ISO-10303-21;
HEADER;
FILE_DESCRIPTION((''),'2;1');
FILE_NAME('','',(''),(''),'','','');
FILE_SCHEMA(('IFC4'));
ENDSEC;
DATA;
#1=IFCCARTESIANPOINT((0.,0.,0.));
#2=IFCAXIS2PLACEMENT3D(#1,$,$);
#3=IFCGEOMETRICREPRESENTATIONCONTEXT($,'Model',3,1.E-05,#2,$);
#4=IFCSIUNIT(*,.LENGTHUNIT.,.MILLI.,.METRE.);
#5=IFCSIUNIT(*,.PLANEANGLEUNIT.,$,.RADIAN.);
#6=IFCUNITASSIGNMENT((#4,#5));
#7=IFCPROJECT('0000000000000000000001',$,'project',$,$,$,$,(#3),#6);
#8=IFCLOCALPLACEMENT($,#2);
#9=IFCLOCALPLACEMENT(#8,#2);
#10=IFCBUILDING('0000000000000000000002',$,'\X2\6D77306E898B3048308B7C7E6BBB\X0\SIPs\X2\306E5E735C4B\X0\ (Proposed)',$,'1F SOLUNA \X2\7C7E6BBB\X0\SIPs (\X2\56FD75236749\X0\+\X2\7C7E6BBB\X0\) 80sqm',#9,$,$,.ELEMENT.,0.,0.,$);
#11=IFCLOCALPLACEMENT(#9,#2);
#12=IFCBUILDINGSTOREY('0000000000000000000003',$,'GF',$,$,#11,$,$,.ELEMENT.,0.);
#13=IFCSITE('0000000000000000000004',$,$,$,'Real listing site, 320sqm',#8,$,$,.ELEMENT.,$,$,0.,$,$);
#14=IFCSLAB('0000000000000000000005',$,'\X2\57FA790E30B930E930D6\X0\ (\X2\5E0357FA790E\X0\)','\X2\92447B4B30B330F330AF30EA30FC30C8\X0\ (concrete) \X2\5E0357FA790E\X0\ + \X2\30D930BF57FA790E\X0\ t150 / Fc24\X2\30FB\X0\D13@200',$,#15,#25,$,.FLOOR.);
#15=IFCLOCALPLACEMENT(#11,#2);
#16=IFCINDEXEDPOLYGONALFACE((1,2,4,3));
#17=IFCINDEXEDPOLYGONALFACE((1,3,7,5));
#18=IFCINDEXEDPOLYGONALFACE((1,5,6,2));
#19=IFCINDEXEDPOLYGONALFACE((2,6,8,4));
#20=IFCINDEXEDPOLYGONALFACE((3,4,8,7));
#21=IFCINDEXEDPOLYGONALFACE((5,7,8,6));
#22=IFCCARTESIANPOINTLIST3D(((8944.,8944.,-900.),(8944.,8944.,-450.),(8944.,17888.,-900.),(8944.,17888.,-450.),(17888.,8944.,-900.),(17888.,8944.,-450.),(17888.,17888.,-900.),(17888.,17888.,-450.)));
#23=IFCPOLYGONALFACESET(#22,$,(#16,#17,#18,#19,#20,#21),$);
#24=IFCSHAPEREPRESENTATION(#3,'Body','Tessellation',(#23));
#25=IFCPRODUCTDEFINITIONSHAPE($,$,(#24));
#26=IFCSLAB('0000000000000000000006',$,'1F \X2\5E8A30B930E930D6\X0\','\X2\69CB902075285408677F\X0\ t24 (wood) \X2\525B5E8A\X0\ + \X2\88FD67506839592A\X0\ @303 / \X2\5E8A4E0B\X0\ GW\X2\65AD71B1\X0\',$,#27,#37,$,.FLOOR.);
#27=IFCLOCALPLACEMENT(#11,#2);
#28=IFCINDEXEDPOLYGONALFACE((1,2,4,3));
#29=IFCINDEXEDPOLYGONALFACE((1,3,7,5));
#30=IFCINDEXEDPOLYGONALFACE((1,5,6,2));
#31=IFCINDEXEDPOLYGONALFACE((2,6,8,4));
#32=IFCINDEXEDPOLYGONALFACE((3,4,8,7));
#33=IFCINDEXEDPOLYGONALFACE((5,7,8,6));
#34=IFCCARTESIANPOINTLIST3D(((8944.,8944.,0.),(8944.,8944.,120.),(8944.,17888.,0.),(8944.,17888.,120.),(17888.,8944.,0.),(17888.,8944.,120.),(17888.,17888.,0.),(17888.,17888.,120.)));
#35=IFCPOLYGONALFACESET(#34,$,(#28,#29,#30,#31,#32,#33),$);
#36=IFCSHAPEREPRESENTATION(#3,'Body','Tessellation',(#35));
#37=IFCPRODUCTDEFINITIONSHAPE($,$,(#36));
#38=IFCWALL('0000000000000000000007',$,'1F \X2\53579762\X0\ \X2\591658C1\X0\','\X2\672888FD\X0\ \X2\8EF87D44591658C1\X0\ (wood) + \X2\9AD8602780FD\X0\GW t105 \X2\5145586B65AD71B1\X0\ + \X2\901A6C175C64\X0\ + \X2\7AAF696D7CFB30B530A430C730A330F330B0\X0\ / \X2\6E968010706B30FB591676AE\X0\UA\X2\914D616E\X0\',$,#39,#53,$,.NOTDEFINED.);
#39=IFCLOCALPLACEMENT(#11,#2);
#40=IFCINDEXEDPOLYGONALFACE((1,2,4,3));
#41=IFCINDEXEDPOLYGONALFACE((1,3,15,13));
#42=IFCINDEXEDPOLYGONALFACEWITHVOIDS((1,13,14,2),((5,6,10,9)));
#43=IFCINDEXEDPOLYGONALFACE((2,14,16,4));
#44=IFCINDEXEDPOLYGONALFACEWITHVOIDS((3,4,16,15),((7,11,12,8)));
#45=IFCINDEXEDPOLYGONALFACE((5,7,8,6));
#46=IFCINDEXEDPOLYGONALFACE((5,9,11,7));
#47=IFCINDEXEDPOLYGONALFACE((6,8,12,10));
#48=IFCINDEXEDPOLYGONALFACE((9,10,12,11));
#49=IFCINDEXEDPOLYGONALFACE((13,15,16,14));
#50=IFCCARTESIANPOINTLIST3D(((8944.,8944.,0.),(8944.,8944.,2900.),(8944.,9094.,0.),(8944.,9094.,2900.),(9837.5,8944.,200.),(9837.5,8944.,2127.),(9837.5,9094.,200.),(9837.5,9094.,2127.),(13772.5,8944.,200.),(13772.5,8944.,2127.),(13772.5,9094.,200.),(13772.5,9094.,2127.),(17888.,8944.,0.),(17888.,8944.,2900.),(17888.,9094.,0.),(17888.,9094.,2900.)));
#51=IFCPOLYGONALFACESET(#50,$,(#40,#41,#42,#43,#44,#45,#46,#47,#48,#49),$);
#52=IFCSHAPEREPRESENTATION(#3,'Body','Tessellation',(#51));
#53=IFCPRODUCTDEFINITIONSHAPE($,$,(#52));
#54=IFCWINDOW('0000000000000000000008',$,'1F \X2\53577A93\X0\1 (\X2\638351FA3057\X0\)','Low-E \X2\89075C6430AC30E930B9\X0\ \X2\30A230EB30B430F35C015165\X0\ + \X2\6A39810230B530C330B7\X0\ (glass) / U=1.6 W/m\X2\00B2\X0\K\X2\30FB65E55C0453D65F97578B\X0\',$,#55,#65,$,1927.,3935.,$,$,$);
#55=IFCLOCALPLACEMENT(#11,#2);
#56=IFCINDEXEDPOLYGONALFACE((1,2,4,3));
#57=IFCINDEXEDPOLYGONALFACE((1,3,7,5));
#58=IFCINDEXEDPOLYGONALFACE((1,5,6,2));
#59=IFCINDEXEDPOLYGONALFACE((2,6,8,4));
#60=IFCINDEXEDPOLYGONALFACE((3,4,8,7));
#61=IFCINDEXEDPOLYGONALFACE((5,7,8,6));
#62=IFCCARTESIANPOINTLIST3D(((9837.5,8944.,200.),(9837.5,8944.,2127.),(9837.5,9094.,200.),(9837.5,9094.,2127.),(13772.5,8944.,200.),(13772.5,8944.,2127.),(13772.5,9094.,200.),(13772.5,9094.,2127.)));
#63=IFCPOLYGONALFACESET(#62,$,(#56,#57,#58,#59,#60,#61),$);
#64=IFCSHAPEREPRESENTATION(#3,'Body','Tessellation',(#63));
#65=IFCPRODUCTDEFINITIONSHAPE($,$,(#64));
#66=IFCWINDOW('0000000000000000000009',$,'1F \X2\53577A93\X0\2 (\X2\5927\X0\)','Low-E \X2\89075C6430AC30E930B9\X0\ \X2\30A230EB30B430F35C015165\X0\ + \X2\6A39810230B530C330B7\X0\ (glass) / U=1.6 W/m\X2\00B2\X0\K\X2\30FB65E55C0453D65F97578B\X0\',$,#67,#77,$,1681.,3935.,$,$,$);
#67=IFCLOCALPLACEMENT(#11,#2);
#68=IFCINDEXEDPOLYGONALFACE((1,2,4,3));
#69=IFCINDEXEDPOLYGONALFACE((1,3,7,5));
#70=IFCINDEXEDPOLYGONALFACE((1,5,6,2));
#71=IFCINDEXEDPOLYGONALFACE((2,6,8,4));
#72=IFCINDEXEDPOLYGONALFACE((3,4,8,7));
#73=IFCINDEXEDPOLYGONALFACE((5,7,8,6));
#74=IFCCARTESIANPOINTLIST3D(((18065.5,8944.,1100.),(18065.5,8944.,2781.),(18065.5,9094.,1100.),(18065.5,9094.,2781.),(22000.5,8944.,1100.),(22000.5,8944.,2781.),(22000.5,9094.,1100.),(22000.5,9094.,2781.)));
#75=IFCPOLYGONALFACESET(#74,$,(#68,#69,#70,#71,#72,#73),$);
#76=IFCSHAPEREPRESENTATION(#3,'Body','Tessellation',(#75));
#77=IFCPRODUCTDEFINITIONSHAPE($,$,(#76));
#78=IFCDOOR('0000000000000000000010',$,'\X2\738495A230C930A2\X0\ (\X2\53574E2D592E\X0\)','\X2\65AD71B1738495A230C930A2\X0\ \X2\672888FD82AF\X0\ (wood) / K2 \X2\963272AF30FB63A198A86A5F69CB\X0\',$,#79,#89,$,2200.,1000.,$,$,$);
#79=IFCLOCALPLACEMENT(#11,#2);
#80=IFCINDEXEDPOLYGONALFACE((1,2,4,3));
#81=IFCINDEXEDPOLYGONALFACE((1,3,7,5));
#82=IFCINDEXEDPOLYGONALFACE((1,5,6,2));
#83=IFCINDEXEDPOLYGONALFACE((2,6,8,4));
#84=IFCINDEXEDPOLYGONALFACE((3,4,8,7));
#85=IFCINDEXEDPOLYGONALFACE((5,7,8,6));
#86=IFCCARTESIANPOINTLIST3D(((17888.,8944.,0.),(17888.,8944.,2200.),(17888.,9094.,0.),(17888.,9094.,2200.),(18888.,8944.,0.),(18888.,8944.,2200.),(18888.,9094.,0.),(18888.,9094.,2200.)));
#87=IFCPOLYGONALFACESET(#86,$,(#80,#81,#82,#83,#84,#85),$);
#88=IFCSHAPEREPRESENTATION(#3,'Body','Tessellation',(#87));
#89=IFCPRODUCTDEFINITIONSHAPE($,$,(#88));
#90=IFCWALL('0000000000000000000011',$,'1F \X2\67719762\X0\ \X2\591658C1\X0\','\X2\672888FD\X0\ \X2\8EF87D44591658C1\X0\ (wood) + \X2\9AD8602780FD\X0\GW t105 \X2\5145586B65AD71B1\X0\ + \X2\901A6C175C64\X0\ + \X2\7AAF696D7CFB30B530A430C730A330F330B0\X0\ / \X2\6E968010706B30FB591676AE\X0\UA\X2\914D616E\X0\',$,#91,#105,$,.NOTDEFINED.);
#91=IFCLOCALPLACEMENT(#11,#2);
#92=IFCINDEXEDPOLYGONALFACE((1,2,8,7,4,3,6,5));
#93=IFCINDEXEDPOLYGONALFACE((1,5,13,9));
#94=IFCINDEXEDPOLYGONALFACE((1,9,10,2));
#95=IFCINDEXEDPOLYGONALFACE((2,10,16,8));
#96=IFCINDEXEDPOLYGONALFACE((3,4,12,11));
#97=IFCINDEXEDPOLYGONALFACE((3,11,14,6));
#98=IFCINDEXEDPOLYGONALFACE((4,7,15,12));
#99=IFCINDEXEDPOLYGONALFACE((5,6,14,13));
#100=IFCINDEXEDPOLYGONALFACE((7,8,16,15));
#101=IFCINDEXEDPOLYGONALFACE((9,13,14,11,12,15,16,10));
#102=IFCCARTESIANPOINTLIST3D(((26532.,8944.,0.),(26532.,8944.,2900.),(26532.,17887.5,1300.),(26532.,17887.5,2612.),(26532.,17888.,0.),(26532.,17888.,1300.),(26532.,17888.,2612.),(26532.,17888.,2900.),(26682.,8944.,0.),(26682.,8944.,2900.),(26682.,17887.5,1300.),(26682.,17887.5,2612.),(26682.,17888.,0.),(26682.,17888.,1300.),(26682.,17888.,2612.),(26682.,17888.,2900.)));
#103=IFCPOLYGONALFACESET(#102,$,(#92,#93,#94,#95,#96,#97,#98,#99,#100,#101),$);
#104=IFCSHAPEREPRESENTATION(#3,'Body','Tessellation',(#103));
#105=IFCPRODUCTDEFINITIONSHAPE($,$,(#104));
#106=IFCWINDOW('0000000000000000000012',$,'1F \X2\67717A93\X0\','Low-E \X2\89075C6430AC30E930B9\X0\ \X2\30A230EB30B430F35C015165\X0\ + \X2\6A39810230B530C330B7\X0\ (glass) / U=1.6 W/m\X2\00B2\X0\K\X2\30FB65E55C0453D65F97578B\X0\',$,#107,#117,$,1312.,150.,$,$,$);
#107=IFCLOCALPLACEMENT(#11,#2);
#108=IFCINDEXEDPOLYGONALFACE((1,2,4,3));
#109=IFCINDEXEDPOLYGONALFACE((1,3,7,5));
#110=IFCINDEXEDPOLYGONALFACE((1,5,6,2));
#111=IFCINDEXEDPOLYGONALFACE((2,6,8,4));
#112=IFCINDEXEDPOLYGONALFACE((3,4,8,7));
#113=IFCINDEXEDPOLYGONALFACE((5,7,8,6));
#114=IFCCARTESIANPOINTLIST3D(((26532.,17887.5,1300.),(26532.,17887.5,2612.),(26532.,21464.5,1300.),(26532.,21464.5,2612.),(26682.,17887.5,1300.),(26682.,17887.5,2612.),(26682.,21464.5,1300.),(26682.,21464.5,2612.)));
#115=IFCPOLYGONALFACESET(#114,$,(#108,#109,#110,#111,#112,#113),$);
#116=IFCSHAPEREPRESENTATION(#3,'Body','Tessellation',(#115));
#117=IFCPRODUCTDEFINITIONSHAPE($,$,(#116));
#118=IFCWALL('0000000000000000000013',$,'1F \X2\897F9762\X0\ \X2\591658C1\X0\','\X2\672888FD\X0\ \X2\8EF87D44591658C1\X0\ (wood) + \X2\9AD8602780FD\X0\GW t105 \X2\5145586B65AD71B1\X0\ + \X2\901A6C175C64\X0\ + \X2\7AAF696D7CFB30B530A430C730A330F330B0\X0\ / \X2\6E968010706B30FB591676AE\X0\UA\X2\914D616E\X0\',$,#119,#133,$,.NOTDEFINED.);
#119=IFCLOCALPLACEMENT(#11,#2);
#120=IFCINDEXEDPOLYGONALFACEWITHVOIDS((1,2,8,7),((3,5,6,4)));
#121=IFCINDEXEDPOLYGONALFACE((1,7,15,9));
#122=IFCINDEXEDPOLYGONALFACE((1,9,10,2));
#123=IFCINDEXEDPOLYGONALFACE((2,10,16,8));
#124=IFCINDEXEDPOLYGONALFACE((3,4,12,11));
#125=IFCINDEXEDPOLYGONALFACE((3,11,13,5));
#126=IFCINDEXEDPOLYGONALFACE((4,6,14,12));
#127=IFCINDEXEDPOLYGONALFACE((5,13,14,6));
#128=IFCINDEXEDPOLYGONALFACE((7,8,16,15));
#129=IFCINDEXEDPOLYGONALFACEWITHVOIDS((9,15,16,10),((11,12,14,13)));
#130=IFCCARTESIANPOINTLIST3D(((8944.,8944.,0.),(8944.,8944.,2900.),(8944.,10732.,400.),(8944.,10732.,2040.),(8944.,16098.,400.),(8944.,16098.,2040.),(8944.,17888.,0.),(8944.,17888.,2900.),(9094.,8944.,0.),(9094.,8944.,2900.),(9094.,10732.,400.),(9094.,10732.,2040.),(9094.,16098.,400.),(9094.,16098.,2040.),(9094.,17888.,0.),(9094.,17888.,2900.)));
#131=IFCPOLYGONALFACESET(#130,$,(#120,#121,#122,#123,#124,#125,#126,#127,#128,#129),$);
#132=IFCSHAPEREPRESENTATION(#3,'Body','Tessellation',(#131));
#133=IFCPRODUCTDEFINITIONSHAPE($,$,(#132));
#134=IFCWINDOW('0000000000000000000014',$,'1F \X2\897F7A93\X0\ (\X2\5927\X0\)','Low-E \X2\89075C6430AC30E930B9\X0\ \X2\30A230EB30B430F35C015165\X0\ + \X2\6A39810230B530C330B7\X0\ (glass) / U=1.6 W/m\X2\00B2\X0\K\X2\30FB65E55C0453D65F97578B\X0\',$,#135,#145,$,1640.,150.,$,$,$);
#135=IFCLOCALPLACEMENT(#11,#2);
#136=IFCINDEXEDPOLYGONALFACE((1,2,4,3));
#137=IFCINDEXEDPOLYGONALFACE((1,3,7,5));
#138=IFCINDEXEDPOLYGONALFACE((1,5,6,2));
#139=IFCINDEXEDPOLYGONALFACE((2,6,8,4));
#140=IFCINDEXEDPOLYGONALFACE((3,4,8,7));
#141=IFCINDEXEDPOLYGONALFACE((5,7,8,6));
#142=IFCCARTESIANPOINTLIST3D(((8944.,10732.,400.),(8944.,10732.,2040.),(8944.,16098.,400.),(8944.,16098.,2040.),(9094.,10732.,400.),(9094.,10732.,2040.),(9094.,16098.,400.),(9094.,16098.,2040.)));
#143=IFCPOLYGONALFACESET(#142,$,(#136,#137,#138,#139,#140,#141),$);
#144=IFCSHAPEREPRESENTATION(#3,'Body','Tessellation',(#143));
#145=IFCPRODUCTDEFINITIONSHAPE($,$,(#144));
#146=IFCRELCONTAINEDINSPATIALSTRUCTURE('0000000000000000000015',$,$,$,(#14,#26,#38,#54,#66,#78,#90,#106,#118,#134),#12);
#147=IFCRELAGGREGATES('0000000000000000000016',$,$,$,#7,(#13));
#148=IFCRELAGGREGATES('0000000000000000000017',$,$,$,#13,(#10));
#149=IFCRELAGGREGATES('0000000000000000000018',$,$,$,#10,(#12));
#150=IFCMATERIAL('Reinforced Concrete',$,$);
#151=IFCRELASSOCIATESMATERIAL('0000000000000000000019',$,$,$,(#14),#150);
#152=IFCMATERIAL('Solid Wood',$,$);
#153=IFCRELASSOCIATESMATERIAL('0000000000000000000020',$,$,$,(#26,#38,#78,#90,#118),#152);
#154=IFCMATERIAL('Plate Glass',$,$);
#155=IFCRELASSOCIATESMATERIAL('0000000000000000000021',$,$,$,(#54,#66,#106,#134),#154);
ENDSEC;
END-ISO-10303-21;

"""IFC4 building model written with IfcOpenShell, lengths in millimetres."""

from ifc_helpers import new_model, si_unit, frame, frame_2d, origin, place, context, project, spatial, rectangle, extrude, material, element, fill, save


model = new_model("IFC4")

# Units and contexts
model_context = context("Model", 3, precision=1e-05, world=origin())
ifc_project = project(units=[si_unit("LENGTHUNIT", "METRE", prefix="MILLI"), si_unit("PLANEANGLEUNIT", "RADIAN")], contexts=[model_context])

# Site, building, storey
site_placement = place(None, origin())
site = spatial("IfcSite", under=ifc_project, at=site_placement, ObjectType="Real listing site, 320sqm", CompositionType="ELEMENT", RefElevation=0.0)
building_placement = place(site_placement, origin())
building = spatial("IfcBuilding", under=site, at=building_placement, Name="海の見える籾殻SIPsの平屋 (Proposed)", ObjectType="1F SOLUNA 籾殻SIPs (国産杉+籾殻) 80sqm", CompositionType="ELEMENT", ElevationOfRefHeight=0.0, ElevationOfTerrain=0.0)
storey_placement = place(building_placement, origin())
storey = spatial("IfcBuildingStorey", under=building, at=storey_placement, Name="GF", CompositionType="ELEMENT", Elevation=0.0)

# Slabs
ifc_material_1 = material(Name="Reinforced Concrete")
slab_1_placement = place(storey_placement, frame((4472.0, 4472.0, -450.0)))
element("IfcSlab", 1, at=slab_1_placement, inside=storey, material=ifc_material_1, Name="基礎スラブ (布基礎)", Description="鉄筋コンクリート (concrete) 布基礎 + ベタ基礎 t150 / Fc24・D13@200", PredefinedType="FLOOR", context=model_context, shape_type="SweptSolid", body=[
    extrude(rectangle(XDim=8944.0, YDim=8944.0, at=frame_2d((4472.0, 4472.0))), frame((4472.0, 4472.0, -450.0)), (0.0, 0.0, 1.0), 450.0),
])
ifc_material_2 = material(Name="Solid Wood")
slab_2_placement = place(storey_placement, frame((4472.0, 4472.0, 0.0)))
element("IfcSlab", 2, at=slab_2_placement, inside=storey, material=ifc_material_2, Name="1F 床スラブ", Description="構造用合板 t24 (wood) 剛床 + 製材根太 @303 / 床下 GW断熱", PredefinedType="FLOOR", context=model_context, shape_type="SweptSolid", body=[
    extrude(rectangle(XDim=8944.0, YDim=8944.0, at=frame_2d((4472.0, 4472.0))), frame((4472.0, 4472.0, 0.0)), (0.0, 0.0, 1.0), 120.0),
])

# Wall, openings, windows, door
wall_1_placement = place(storey_placement, frame((4472.0, 4472.0, 0.0)))
wall_1 = element("IfcWall", 3, at=wall_1_placement, inside=storey, material=ifc_material_2, Name="1F 南面 外壁", Description="木製 軸組外壁 (wood) + 高性能GW t105 充填断熱 + 通気層 + 窯業系サイディング / 準耐火・外皮UA配慮", PredefinedType="NOTDEFINED", context=model_context, shape_type="SweptSolid", body=[
    extrude(rectangle(XDim=8944.0, YDim=150.0, at=frame_2d((4472.0, 75.0))), frame((4472.0, 4472.0, 0.0)), (0.0, 0.0, 1.0), 2900.0),
])
opening_1_placement = place(storey_placement, frame((4919.0, 4472.0, 100.0)))
opening_1 = element("IfcOpeningElement", 4, at=opening_1_placement, cuts=wall_1, PredefinedType="NOTDEFINED", context=model_context, shape_type="SweptSolid", body=[
    extrude(rectangle(XDim=3935.0, YDim=150.0, at=frame_2d((1967.0, 75.0))), frame((4919.0, 4472.0, 100.0)), (0.0, 0.0, 1.0), 1927.0),
])
opening_2_placement = place(storey_placement, frame((9033.0, 4472.0, 550.0)))
opening_2 = element("IfcOpeningElement", 5, at=opening_2_placement, cuts=wall_1, PredefinedType="NOTDEFINED", context=model_context, shape_type="SweptSolid", body=[
    extrude(rectangle(XDim=3935.0, YDim=150.0, at=frame_2d((1967.0, 75.0))), frame((9033.0, 4472.0, 550.0)), (0.0, 0.0, 1.0), 1681.0),
])
opening_3_placement = place(storey_placement, frame((8944.0, 4472.0, 0.0)))
opening_3 = element("IfcOpeningElement", 6, at=opening_3_placement, cuts=wall_1, PredefinedType="NOTDEFINED", context=model_context, shape_type="SweptSolid", body=[
    extrude(rectangle(XDim=1000.0, YDim=150.0, at=frame_2d((500.0, 75.0))), frame((8944.0, 4472.0, 0.0)), (0.0, 0.0, 1.0), 2200.0),
])
ifc_material_3 = material(Name="Plate Glass")
window_1_placement = place(storey_placement, frame((4919.0, 4472.0, 100.0)))
window_1 = element("IfcWindow", 7, at=window_1_placement, inside=storey, material=ifc_material_3, Name="1F 南窓1 (掃出し)", Description="Low-E 複層ガラス アルゴン封入 + 樹脂サッシ (glass) / U=1.6 W/m²K・日射取得型", OverallHeight=1927.0, OverallWidth=3935.0, context=model_context, shape_type="SweptSolid", body=[
    extrude(rectangle(XDim=3935.0, YDim=150.0, at=frame_2d((1967.0, 75.0))), frame((4919.0, 4472.0, 100.0)), (0.0, 0.0, 1.0), 1927.0),
])
fill(opening_1, window_1)
window_2_placement = place(storey_placement, frame((9033.0, 4472.0, 550.0)))
window_2 = element("IfcWindow", 8, at=window_2_placement, inside=storey, material=ifc_material_3, Name="1F 南窓2 (大)", Description="Low-E 複層ガラス アルゴン封入 + 樹脂サッシ (glass) / U=1.6 W/m²K・日射取得型", OverallHeight=1681.0, OverallWidth=3935.0, context=model_context, shape_type="SweptSolid", body=[
    extrude(rectangle(XDim=3935.0, YDim=150.0, at=frame_2d((1967.0, 75.0))), frame((9033.0, 4472.0, 550.0)), (0.0, 0.0, 1.0), 1681.0),
])
fill(opening_2, window_2)
door_placement = place(storey_placement, frame((8944.0, 4472.0, 0.0)))
door = element("IfcDoor", 9, at=door_placement, inside=storey, material=ifc_material_2, Name="玄関ドア (南中央)", Description="断熱玄関ドア 木製芯 (wood) / K2 防犯・採風機構", OverallHeight=2200.0, OverallWidth=1000.0, context=model_context, shape_type="SweptSolid", body=[
    extrude(rectangle(XDim=1000.0, YDim=150.0, at=frame_2d((500.0, 75.0))), frame((8944.0, 4472.0, 0.0)), (0.0, 0.0, 1.0), 2200.0),
])
fill(opening_3, door)

# Walls, openings, windows
wall_2_placement = place(storey_placement, frame((13266.0, 4472.0, 0.0)))
wall_2 = element("IfcWall", 10, at=wall_2_placement, inside=storey, material=ifc_material_2, Name="1F 東面 外壁", Description="木製 軸組外壁 (wood) + 高性能GW t105 充填断熱 + 通気層 + 窯業系サイディング / 準耐火・外皮UA配慮", PredefinedType="NOTDEFINED", context=model_context, shape_type="SweptSolid", body=[
    extrude(rectangle(XDim=150.0, YDim=8944.0, at=frame_2d((75.0, 4472.0))), frame((13266.0, 4472.0, 0.0)), (0.0, 0.0, 1.0), 2900.0),
])
opening_4_placement = place(storey_placement, frame((13266.0, 8944.0, 650.0)))
opening_4 = element("IfcOpeningElement", 11, at=opening_4_placement, cuts=wall_2, PredefinedType="NOTDEFINED", context=model_context, shape_type="SweptSolid", body=[
    extrude(rectangle(XDim=150.0, YDim=3577.0, at=frame_2d((75.0, 1788.0))), frame((13266.0, 8944.0, 650.0)), (0.0, 0.0, 1.0), 1312.0),
])
window_3_placement = place(storey_placement, frame((13266.0, 8944.0, 650.0)))
window_3 = element("IfcWindow", 12, at=window_3_placement, inside=storey, material=ifc_material_3, Name="1F 東窓", Description="Low-E 複層ガラス アルゴン封入 + 樹脂サッシ (glass) / U=1.6 W/m²K・日射取得型", OverallHeight=1312.0, OverallWidth=150.0, context=model_context, shape_type="SweptSolid", body=[
    extrude(rectangle(XDim=150.0, YDim=3577.0, at=frame_2d((75.0, 1788.0))), frame((13266.0, 8944.0, 650.0)), (0.0, 0.0, 1.0), 1312.0),
])
fill(opening_4, window_3)
wall_3_placement = place(storey_placement, frame((4472.0, 4472.0, 0.0)))
wall_3 = element("IfcWall", 13, at=wall_3_placement, inside=storey, material=ifc_material_2, Name="1F 西面 外壁", Description="木製 軸組外壁 (wood) + 高性能GW t105 充填断熱 + 通気層 + 窯業系サイディング / 準耐火・外皮UA配慮", PredefinedType="NOTDEFINED", context=model_context, shape_type="SweptSolid", body=[
    extrude(rectangle(XDim=150.0, YDim=8944.0, at=frame_2d((75.0, 4472.0))), frame((4472.0, 4472.0, 0.0)), (0.0, 0.0, 1.0), 2900.0),
])
opening_5_placement = place(storey_placement, frame((4472.0, 5366.0, 200.0)))
opening_5 = element("IfcOpeningElement", 14, at=opening_5_placement, cuts=wall_3, PredefinedType="NOTDEFINED", context=model_context, shape_type="SweptSolid", body=[
    extrude(rectangle(XDim=150.0, YDim=5366.0, at=frame_2d((75.0, 2683.0))), frame((4472.0, 5366.0, 200.0)), (0.0, 0.0, 1.0), 1640.0),
])
window_4_placement = place(storey_placement, frame((4472.0, 5366.0, 200.0)))
window_4 = element("IfcWindow", 15, at=window_4_placement, inside=storey, material=ifc_material_3, Name="1F 西窓 (大)", Description="Low-E 複層ガラス アルゴン封入 + 樹脂サッシ (glass) / U=1.6 W/m²K・日射取得型", OverallHeight=1640.0, OverallWidth=150.0, context=model_context, shape_type="SweptSolid", body=[
    extrude(rectangle(XDim=150.0, YDim=5366.0, at=frame_2d((75.0, 2683.0))), frame((4472.0, 5366.0, 200.0)), (0.0, 0.0, 1.0), 1640.0),
])
fill(opening_5, window_4)

save(model, "model.ifc")
